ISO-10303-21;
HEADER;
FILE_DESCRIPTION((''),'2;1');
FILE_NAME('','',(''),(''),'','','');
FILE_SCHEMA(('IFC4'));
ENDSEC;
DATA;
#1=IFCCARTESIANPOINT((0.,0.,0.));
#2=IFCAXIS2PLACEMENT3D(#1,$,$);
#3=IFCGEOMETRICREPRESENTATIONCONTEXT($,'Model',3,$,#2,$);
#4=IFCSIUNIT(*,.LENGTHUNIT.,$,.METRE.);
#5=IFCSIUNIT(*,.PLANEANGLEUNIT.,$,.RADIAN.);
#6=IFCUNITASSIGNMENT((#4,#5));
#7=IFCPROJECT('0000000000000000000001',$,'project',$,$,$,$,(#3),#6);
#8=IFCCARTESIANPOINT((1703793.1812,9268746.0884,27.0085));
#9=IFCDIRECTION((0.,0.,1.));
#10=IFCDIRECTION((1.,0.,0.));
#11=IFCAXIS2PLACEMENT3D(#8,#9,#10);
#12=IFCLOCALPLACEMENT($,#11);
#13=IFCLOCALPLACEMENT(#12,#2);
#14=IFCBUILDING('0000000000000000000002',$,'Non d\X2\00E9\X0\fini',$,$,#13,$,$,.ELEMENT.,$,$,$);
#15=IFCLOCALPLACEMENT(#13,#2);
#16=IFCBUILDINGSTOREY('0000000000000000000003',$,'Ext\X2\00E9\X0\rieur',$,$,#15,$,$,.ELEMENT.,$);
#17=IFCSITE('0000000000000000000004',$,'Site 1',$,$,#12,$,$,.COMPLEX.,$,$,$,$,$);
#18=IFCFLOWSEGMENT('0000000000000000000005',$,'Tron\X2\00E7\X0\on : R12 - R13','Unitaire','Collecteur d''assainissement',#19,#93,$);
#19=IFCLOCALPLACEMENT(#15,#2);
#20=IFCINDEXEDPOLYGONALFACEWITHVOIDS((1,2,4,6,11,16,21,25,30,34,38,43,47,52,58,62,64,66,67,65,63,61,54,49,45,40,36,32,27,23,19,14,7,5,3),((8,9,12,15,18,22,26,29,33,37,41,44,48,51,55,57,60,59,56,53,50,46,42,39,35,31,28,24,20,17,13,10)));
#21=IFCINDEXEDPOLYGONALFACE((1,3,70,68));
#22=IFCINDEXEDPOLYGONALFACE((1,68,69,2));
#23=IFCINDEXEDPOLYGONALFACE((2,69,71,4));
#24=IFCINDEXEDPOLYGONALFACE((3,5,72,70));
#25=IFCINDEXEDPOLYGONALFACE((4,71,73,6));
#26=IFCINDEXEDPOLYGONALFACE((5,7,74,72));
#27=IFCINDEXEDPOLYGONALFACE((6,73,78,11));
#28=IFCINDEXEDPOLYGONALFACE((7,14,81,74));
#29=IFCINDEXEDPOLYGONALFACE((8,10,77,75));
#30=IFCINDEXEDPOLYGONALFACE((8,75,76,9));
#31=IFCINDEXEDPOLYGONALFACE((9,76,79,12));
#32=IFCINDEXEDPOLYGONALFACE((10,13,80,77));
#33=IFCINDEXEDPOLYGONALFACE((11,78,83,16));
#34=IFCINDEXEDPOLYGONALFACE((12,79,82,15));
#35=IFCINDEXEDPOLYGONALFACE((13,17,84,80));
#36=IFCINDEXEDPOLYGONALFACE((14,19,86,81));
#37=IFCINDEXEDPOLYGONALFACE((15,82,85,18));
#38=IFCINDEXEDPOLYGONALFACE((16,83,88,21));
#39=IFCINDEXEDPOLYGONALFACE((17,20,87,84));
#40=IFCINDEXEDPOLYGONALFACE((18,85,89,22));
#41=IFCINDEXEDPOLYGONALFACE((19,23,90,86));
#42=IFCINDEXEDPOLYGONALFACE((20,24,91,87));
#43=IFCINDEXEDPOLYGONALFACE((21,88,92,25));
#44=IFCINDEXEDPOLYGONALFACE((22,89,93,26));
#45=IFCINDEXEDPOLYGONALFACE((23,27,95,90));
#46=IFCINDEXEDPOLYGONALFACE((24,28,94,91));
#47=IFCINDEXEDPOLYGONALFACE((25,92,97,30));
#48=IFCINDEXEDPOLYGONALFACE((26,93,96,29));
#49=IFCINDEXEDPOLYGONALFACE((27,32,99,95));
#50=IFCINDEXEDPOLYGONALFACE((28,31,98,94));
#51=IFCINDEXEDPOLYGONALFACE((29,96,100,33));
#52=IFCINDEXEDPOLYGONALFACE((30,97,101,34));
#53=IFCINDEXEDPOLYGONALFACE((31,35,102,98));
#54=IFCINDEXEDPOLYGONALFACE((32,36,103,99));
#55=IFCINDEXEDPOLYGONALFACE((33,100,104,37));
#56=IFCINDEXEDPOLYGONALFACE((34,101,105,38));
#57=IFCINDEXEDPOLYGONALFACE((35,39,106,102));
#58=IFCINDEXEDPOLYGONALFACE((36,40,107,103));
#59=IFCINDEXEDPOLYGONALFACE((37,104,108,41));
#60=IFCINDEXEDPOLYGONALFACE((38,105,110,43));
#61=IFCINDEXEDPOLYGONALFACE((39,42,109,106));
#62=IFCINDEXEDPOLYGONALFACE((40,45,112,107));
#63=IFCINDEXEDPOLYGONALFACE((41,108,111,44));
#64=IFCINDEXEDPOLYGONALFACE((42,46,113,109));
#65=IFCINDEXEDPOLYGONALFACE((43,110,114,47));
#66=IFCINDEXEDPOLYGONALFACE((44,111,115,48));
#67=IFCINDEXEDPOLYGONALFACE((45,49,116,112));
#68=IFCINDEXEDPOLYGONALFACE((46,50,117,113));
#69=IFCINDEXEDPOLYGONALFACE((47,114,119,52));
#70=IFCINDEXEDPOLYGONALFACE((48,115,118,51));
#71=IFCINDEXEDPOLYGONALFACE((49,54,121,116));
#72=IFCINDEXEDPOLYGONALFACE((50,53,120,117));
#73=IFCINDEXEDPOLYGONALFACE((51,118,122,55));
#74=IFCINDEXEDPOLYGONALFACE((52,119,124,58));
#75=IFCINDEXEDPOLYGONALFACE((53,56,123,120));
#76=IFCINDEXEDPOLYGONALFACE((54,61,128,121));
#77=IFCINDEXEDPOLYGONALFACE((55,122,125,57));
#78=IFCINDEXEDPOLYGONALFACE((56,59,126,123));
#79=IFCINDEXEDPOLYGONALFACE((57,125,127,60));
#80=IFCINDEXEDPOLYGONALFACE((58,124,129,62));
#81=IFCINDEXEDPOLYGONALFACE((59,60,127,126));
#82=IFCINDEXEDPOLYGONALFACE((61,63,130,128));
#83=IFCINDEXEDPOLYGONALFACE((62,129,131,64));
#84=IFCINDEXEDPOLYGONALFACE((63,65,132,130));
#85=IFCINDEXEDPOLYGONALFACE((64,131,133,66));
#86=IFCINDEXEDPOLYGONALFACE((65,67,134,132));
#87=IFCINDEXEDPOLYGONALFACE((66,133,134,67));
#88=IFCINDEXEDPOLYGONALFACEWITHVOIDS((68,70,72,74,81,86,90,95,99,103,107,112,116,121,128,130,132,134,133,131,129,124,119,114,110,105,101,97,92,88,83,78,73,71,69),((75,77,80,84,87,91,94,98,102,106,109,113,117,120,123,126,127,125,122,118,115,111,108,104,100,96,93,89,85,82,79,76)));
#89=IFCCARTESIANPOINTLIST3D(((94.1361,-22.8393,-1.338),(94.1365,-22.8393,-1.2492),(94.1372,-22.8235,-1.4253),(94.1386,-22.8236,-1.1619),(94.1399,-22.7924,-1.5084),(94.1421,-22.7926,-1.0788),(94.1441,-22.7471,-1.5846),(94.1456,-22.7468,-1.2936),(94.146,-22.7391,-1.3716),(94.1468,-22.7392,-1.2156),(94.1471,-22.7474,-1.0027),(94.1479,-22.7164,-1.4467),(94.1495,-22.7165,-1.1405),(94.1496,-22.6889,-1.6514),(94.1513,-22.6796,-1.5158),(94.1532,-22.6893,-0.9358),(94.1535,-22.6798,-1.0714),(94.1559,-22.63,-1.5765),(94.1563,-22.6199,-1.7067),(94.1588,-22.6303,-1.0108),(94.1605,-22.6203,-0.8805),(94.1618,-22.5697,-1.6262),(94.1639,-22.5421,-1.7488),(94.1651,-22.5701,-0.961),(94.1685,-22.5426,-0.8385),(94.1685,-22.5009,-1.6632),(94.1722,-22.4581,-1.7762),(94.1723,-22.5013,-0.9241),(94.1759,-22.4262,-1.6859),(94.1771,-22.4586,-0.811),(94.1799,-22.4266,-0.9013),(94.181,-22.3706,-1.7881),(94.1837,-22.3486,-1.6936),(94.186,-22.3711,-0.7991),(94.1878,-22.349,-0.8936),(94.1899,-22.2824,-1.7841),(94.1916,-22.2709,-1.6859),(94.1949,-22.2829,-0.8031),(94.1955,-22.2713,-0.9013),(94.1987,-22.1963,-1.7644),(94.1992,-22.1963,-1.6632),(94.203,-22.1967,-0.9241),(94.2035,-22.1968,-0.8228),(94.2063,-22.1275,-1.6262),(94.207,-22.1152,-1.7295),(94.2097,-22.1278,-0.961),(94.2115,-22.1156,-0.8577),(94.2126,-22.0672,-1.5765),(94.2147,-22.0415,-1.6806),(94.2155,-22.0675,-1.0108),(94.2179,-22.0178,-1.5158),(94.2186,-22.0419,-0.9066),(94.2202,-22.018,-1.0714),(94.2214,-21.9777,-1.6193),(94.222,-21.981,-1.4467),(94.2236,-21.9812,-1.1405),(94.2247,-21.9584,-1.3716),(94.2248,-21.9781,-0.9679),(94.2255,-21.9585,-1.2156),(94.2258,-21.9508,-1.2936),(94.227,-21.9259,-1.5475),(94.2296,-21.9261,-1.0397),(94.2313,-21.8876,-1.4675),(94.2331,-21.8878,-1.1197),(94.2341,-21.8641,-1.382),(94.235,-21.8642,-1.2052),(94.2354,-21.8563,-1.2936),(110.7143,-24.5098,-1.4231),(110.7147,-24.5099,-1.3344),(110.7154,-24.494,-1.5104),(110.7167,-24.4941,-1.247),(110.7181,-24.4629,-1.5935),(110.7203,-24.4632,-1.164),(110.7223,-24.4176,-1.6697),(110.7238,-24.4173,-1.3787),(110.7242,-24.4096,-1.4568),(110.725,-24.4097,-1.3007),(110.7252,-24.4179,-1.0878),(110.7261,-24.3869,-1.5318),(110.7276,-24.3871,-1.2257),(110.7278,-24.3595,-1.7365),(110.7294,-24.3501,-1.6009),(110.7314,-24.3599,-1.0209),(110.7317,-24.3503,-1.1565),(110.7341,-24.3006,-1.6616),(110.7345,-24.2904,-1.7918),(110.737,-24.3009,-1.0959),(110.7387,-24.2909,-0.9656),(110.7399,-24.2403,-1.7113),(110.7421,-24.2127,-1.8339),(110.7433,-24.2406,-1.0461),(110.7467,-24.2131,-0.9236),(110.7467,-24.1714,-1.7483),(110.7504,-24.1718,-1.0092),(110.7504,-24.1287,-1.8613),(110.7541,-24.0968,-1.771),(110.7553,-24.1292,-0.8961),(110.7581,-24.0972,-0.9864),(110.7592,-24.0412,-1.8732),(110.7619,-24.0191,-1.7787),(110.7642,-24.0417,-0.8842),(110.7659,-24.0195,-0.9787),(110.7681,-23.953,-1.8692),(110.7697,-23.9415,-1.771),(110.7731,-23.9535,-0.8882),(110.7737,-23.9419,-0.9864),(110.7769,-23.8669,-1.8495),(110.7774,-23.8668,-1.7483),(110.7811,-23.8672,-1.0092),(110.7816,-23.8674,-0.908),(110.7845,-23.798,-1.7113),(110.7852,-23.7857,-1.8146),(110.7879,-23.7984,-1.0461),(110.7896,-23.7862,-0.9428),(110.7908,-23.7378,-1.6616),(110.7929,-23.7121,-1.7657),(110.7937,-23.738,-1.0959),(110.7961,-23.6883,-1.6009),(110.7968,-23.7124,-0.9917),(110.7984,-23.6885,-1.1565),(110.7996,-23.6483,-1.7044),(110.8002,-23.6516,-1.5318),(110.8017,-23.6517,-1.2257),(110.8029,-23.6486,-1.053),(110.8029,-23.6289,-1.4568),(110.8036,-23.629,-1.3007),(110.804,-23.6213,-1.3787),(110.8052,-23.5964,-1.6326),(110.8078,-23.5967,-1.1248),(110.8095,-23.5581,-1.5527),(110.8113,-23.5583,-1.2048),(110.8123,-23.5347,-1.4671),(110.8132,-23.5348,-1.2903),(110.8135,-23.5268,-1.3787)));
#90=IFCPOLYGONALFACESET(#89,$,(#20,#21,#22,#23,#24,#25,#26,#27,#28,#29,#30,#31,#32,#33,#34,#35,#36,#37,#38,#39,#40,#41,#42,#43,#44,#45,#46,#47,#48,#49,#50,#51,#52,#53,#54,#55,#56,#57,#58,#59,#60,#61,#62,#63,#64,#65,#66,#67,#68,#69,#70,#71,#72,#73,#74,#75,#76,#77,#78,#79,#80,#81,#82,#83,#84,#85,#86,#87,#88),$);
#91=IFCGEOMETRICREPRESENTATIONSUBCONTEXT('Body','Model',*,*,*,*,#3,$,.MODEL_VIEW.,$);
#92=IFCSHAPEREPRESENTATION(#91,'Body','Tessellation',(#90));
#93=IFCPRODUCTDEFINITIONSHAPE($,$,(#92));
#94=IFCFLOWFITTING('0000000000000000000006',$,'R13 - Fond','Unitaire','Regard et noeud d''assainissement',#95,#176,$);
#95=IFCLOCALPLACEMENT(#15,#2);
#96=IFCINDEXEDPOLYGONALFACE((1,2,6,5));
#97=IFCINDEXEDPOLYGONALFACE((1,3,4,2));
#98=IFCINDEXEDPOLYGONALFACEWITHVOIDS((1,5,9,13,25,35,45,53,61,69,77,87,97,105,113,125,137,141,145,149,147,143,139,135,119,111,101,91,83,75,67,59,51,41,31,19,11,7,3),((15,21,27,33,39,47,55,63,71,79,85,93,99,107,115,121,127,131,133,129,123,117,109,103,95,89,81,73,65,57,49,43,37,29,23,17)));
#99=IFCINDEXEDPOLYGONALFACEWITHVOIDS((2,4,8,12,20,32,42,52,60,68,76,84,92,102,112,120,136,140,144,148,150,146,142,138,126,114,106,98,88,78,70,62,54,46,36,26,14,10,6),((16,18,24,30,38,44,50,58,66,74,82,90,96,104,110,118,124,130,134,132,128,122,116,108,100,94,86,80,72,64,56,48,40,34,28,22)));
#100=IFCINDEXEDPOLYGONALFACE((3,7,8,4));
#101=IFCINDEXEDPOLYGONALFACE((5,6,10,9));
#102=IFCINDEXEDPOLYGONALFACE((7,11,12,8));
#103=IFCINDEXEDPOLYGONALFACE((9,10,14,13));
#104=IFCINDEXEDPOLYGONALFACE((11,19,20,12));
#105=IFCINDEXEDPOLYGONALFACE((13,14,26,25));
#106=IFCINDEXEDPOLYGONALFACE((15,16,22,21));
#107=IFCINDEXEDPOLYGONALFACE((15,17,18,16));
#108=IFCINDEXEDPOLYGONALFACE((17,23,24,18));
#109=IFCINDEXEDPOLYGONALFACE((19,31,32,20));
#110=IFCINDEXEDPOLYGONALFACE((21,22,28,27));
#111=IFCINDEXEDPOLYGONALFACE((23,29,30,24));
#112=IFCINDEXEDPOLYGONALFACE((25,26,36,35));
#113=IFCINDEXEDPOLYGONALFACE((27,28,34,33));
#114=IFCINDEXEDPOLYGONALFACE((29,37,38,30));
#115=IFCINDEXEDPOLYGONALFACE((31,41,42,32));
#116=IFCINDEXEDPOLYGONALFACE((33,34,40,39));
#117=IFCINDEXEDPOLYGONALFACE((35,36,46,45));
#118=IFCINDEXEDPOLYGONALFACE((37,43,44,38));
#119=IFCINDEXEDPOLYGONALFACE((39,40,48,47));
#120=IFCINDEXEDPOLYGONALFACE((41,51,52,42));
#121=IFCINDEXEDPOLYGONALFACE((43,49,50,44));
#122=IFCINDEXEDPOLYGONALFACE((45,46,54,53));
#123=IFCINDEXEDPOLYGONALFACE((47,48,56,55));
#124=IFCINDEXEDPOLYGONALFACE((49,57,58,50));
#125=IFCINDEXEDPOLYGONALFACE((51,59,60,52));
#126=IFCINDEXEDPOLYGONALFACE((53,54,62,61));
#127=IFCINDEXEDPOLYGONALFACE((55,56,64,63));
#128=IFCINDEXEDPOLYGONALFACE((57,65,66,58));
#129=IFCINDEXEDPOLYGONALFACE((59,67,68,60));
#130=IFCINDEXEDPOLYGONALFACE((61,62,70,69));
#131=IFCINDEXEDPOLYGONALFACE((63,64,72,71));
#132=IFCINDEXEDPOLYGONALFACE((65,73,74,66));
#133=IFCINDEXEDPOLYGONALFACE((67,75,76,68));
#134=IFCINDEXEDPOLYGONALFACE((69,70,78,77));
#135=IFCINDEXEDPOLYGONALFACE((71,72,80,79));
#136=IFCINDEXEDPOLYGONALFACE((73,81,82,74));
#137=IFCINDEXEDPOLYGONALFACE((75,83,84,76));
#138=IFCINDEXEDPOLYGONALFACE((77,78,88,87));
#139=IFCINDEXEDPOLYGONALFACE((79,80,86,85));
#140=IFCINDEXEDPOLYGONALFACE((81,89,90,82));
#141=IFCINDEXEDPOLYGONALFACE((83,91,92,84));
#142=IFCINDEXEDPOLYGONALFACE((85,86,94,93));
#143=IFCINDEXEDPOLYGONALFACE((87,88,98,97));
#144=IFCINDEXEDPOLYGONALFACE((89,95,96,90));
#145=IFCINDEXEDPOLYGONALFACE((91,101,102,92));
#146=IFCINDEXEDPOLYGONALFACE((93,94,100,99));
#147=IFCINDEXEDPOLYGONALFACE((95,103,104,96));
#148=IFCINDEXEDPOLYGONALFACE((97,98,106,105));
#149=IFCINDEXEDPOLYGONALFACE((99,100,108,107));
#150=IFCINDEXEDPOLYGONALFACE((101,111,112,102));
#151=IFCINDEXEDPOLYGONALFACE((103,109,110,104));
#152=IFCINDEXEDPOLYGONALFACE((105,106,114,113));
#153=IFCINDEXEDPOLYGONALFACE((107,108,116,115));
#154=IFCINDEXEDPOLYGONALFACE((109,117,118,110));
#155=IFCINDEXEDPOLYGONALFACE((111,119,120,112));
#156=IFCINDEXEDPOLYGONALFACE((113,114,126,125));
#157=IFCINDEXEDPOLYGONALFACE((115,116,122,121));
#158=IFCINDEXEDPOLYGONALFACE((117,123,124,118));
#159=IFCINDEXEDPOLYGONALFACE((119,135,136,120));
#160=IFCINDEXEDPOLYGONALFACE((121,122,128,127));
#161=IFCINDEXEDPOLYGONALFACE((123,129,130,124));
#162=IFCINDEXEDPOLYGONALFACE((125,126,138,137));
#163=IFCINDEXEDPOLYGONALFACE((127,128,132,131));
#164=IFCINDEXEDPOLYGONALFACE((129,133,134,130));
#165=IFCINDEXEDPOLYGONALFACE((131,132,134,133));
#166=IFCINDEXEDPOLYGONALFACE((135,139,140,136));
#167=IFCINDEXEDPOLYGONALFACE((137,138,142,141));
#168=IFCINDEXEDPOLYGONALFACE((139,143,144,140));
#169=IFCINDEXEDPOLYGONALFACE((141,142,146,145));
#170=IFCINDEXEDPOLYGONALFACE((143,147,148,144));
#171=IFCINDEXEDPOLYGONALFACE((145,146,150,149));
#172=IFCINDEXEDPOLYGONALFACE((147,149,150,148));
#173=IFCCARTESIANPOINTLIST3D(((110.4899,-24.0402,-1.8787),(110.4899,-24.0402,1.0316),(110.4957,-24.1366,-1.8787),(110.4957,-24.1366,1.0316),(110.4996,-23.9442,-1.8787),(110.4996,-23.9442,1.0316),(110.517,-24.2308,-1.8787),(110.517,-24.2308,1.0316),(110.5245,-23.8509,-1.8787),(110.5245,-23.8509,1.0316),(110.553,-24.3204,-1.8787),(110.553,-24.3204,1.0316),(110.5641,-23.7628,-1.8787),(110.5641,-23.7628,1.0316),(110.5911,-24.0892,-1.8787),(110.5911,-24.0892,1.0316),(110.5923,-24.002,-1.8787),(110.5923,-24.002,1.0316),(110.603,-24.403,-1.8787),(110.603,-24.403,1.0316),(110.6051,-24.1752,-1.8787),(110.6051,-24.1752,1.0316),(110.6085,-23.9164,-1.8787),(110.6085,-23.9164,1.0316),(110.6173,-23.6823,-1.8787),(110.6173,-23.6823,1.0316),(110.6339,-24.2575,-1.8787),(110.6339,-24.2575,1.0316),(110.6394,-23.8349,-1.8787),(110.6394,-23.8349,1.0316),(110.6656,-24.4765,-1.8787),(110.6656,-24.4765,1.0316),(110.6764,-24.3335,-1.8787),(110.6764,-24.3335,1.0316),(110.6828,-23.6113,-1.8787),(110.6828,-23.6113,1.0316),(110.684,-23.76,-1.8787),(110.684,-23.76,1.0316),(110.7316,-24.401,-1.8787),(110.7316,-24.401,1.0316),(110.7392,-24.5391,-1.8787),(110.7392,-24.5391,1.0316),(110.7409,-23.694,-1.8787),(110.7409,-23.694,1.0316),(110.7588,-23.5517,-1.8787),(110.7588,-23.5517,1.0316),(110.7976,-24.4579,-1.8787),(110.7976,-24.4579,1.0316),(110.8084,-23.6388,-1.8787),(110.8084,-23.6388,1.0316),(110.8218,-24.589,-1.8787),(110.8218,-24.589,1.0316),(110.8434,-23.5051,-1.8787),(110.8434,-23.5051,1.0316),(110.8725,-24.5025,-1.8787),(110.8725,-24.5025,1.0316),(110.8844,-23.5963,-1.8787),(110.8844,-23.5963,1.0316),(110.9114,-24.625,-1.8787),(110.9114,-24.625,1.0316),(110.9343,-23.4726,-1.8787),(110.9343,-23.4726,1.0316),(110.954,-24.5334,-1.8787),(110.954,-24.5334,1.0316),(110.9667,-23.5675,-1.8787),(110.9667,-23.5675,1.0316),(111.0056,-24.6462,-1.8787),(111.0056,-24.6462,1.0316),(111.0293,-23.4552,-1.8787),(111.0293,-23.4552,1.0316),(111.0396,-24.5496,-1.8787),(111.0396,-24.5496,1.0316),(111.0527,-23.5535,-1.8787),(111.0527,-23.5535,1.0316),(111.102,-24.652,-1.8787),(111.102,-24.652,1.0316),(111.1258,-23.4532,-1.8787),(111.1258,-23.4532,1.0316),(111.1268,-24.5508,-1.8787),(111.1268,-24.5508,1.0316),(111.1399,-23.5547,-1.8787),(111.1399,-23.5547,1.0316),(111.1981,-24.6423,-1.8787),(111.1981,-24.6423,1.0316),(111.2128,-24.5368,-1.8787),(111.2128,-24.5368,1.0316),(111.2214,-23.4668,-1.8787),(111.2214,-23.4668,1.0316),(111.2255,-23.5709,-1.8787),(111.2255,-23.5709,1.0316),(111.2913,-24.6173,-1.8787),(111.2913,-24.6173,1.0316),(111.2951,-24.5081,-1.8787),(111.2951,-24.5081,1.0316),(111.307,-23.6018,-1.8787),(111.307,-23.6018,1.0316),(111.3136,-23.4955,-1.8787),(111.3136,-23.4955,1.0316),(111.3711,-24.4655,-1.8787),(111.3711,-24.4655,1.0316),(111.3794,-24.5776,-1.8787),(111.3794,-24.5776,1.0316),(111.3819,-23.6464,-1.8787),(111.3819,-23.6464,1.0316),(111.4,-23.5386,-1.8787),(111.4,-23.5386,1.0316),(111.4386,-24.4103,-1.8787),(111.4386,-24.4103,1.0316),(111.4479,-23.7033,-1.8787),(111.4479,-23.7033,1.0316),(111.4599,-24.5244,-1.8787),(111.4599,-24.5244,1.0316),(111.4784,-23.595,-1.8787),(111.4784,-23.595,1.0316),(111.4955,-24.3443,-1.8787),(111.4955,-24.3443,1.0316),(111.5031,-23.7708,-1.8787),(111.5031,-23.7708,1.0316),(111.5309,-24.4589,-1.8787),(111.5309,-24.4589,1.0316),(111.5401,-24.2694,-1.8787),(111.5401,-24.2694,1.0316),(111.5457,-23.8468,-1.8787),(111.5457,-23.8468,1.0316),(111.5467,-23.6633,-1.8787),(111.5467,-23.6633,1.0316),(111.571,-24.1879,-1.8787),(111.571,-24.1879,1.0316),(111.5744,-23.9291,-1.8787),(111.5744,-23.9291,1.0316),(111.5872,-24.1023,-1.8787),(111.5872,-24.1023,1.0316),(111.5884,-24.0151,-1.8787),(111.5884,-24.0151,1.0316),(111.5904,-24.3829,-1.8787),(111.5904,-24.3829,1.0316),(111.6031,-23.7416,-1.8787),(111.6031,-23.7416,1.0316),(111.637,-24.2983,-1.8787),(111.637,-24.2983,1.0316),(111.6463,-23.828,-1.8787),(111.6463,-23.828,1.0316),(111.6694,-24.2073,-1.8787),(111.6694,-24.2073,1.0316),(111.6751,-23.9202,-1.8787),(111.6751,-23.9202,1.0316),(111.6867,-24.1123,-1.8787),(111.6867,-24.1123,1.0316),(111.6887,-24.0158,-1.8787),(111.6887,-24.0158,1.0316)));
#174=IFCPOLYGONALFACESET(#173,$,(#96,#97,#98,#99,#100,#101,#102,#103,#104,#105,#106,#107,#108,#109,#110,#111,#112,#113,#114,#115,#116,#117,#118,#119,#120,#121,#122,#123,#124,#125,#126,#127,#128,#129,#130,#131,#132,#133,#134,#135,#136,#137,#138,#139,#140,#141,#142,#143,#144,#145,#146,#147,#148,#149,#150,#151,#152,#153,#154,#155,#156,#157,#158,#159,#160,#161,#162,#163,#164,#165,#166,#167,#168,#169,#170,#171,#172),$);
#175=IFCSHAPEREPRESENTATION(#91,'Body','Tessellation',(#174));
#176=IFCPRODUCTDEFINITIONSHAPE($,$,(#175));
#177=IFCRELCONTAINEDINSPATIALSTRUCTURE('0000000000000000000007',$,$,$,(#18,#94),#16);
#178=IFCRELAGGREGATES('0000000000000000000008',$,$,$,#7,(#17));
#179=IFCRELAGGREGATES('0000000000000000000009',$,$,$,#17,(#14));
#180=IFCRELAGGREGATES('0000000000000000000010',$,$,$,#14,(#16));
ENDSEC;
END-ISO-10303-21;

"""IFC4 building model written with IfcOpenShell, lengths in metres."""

from ifc_helpers import new_model, si_unit, frame, origin, origin_2d, place, context, subcontext, project, spatial, hollow_circle, extrude, element, save


model = new_model("IFC4")

# Units and contexts
model_context = context("Model", 3, world=origin())
body_context = subcontext(model_context, "Body", "Model", "MODEL_VIEW")
ifc_project = project(units=[si_unit("LENGTHUNIT", "METRE"), si_unit("PLANEANGLEUNIT", "RADIAN")], contexts=[model_context])

# Site, building, storey
site_placement = place(None, frame((1703793.1812, 9268746.0884, 27.0085), z_axis=(0.0, 0.0, 1.0), x_axis=(1.0, 0.0, 0.0)))
site = spatial("IfcSite", under=ifc_project, at=site_placement, Name="Site 1", CompositionType="COMPLEX")
building_placement = place(site_placement, origin())
building = spatial("IfcBuilding", under=site, at=building_placement, Name="Non défini", CompositionType="ELEMENT")
storey_placement = place(building_placement, origin())
storey = spatial("IfcBuildingStorey", under=building, at=storey_placement, Name="Extérieur", CompositionType="ELEMENT")

# Flow segment
flow_segment_1_placement = place(storey_placement, origin())
element("IfcFlowSegment", 1, at=flow_segment_1_placement, inside=storey, Name="Tronçon : R12 - R13", Description="Unitaire", ObjectType="Collecteur d'assainissement", context=body_context, shape_type="SweptSolid", body=[
    extrude(hollow_circle(Radius=0.495, WallThickness=0.095, at=origin_2d()), frame((94.1857, -22.3488, -1.2936), z_axis=(0.994948, -0.100259, -0.005108), x_axis=(0.10026, 0.994961, 0.0)), (0.0, 0.0, 1.0), 16.6624),
])

# Flow fitting
flow_fitting_1_placement = place(storey_placement, origin())
element("IfcFlowFitting", 2, at=flow_fitting_1_placement, inside=storey, Name="R13 - Fond", Description="Unitaire", ObjectType="Regard et noeud d'assainissement", context=body_context, shape_type="SweptSolid", body=[
    extrude(hollow_circle(Radius=0.6, WallThickness=0.1, at=origin_2d()), frame((111.0898, -24.0522, -1.8787), z_axis=(0.0, 0.0, 1.0), x_axis=(0.994961, -0.10026, 0.0)), (0.0, 0.0, 1.0), 2.9104),
])

save(model, "model.ifc")
